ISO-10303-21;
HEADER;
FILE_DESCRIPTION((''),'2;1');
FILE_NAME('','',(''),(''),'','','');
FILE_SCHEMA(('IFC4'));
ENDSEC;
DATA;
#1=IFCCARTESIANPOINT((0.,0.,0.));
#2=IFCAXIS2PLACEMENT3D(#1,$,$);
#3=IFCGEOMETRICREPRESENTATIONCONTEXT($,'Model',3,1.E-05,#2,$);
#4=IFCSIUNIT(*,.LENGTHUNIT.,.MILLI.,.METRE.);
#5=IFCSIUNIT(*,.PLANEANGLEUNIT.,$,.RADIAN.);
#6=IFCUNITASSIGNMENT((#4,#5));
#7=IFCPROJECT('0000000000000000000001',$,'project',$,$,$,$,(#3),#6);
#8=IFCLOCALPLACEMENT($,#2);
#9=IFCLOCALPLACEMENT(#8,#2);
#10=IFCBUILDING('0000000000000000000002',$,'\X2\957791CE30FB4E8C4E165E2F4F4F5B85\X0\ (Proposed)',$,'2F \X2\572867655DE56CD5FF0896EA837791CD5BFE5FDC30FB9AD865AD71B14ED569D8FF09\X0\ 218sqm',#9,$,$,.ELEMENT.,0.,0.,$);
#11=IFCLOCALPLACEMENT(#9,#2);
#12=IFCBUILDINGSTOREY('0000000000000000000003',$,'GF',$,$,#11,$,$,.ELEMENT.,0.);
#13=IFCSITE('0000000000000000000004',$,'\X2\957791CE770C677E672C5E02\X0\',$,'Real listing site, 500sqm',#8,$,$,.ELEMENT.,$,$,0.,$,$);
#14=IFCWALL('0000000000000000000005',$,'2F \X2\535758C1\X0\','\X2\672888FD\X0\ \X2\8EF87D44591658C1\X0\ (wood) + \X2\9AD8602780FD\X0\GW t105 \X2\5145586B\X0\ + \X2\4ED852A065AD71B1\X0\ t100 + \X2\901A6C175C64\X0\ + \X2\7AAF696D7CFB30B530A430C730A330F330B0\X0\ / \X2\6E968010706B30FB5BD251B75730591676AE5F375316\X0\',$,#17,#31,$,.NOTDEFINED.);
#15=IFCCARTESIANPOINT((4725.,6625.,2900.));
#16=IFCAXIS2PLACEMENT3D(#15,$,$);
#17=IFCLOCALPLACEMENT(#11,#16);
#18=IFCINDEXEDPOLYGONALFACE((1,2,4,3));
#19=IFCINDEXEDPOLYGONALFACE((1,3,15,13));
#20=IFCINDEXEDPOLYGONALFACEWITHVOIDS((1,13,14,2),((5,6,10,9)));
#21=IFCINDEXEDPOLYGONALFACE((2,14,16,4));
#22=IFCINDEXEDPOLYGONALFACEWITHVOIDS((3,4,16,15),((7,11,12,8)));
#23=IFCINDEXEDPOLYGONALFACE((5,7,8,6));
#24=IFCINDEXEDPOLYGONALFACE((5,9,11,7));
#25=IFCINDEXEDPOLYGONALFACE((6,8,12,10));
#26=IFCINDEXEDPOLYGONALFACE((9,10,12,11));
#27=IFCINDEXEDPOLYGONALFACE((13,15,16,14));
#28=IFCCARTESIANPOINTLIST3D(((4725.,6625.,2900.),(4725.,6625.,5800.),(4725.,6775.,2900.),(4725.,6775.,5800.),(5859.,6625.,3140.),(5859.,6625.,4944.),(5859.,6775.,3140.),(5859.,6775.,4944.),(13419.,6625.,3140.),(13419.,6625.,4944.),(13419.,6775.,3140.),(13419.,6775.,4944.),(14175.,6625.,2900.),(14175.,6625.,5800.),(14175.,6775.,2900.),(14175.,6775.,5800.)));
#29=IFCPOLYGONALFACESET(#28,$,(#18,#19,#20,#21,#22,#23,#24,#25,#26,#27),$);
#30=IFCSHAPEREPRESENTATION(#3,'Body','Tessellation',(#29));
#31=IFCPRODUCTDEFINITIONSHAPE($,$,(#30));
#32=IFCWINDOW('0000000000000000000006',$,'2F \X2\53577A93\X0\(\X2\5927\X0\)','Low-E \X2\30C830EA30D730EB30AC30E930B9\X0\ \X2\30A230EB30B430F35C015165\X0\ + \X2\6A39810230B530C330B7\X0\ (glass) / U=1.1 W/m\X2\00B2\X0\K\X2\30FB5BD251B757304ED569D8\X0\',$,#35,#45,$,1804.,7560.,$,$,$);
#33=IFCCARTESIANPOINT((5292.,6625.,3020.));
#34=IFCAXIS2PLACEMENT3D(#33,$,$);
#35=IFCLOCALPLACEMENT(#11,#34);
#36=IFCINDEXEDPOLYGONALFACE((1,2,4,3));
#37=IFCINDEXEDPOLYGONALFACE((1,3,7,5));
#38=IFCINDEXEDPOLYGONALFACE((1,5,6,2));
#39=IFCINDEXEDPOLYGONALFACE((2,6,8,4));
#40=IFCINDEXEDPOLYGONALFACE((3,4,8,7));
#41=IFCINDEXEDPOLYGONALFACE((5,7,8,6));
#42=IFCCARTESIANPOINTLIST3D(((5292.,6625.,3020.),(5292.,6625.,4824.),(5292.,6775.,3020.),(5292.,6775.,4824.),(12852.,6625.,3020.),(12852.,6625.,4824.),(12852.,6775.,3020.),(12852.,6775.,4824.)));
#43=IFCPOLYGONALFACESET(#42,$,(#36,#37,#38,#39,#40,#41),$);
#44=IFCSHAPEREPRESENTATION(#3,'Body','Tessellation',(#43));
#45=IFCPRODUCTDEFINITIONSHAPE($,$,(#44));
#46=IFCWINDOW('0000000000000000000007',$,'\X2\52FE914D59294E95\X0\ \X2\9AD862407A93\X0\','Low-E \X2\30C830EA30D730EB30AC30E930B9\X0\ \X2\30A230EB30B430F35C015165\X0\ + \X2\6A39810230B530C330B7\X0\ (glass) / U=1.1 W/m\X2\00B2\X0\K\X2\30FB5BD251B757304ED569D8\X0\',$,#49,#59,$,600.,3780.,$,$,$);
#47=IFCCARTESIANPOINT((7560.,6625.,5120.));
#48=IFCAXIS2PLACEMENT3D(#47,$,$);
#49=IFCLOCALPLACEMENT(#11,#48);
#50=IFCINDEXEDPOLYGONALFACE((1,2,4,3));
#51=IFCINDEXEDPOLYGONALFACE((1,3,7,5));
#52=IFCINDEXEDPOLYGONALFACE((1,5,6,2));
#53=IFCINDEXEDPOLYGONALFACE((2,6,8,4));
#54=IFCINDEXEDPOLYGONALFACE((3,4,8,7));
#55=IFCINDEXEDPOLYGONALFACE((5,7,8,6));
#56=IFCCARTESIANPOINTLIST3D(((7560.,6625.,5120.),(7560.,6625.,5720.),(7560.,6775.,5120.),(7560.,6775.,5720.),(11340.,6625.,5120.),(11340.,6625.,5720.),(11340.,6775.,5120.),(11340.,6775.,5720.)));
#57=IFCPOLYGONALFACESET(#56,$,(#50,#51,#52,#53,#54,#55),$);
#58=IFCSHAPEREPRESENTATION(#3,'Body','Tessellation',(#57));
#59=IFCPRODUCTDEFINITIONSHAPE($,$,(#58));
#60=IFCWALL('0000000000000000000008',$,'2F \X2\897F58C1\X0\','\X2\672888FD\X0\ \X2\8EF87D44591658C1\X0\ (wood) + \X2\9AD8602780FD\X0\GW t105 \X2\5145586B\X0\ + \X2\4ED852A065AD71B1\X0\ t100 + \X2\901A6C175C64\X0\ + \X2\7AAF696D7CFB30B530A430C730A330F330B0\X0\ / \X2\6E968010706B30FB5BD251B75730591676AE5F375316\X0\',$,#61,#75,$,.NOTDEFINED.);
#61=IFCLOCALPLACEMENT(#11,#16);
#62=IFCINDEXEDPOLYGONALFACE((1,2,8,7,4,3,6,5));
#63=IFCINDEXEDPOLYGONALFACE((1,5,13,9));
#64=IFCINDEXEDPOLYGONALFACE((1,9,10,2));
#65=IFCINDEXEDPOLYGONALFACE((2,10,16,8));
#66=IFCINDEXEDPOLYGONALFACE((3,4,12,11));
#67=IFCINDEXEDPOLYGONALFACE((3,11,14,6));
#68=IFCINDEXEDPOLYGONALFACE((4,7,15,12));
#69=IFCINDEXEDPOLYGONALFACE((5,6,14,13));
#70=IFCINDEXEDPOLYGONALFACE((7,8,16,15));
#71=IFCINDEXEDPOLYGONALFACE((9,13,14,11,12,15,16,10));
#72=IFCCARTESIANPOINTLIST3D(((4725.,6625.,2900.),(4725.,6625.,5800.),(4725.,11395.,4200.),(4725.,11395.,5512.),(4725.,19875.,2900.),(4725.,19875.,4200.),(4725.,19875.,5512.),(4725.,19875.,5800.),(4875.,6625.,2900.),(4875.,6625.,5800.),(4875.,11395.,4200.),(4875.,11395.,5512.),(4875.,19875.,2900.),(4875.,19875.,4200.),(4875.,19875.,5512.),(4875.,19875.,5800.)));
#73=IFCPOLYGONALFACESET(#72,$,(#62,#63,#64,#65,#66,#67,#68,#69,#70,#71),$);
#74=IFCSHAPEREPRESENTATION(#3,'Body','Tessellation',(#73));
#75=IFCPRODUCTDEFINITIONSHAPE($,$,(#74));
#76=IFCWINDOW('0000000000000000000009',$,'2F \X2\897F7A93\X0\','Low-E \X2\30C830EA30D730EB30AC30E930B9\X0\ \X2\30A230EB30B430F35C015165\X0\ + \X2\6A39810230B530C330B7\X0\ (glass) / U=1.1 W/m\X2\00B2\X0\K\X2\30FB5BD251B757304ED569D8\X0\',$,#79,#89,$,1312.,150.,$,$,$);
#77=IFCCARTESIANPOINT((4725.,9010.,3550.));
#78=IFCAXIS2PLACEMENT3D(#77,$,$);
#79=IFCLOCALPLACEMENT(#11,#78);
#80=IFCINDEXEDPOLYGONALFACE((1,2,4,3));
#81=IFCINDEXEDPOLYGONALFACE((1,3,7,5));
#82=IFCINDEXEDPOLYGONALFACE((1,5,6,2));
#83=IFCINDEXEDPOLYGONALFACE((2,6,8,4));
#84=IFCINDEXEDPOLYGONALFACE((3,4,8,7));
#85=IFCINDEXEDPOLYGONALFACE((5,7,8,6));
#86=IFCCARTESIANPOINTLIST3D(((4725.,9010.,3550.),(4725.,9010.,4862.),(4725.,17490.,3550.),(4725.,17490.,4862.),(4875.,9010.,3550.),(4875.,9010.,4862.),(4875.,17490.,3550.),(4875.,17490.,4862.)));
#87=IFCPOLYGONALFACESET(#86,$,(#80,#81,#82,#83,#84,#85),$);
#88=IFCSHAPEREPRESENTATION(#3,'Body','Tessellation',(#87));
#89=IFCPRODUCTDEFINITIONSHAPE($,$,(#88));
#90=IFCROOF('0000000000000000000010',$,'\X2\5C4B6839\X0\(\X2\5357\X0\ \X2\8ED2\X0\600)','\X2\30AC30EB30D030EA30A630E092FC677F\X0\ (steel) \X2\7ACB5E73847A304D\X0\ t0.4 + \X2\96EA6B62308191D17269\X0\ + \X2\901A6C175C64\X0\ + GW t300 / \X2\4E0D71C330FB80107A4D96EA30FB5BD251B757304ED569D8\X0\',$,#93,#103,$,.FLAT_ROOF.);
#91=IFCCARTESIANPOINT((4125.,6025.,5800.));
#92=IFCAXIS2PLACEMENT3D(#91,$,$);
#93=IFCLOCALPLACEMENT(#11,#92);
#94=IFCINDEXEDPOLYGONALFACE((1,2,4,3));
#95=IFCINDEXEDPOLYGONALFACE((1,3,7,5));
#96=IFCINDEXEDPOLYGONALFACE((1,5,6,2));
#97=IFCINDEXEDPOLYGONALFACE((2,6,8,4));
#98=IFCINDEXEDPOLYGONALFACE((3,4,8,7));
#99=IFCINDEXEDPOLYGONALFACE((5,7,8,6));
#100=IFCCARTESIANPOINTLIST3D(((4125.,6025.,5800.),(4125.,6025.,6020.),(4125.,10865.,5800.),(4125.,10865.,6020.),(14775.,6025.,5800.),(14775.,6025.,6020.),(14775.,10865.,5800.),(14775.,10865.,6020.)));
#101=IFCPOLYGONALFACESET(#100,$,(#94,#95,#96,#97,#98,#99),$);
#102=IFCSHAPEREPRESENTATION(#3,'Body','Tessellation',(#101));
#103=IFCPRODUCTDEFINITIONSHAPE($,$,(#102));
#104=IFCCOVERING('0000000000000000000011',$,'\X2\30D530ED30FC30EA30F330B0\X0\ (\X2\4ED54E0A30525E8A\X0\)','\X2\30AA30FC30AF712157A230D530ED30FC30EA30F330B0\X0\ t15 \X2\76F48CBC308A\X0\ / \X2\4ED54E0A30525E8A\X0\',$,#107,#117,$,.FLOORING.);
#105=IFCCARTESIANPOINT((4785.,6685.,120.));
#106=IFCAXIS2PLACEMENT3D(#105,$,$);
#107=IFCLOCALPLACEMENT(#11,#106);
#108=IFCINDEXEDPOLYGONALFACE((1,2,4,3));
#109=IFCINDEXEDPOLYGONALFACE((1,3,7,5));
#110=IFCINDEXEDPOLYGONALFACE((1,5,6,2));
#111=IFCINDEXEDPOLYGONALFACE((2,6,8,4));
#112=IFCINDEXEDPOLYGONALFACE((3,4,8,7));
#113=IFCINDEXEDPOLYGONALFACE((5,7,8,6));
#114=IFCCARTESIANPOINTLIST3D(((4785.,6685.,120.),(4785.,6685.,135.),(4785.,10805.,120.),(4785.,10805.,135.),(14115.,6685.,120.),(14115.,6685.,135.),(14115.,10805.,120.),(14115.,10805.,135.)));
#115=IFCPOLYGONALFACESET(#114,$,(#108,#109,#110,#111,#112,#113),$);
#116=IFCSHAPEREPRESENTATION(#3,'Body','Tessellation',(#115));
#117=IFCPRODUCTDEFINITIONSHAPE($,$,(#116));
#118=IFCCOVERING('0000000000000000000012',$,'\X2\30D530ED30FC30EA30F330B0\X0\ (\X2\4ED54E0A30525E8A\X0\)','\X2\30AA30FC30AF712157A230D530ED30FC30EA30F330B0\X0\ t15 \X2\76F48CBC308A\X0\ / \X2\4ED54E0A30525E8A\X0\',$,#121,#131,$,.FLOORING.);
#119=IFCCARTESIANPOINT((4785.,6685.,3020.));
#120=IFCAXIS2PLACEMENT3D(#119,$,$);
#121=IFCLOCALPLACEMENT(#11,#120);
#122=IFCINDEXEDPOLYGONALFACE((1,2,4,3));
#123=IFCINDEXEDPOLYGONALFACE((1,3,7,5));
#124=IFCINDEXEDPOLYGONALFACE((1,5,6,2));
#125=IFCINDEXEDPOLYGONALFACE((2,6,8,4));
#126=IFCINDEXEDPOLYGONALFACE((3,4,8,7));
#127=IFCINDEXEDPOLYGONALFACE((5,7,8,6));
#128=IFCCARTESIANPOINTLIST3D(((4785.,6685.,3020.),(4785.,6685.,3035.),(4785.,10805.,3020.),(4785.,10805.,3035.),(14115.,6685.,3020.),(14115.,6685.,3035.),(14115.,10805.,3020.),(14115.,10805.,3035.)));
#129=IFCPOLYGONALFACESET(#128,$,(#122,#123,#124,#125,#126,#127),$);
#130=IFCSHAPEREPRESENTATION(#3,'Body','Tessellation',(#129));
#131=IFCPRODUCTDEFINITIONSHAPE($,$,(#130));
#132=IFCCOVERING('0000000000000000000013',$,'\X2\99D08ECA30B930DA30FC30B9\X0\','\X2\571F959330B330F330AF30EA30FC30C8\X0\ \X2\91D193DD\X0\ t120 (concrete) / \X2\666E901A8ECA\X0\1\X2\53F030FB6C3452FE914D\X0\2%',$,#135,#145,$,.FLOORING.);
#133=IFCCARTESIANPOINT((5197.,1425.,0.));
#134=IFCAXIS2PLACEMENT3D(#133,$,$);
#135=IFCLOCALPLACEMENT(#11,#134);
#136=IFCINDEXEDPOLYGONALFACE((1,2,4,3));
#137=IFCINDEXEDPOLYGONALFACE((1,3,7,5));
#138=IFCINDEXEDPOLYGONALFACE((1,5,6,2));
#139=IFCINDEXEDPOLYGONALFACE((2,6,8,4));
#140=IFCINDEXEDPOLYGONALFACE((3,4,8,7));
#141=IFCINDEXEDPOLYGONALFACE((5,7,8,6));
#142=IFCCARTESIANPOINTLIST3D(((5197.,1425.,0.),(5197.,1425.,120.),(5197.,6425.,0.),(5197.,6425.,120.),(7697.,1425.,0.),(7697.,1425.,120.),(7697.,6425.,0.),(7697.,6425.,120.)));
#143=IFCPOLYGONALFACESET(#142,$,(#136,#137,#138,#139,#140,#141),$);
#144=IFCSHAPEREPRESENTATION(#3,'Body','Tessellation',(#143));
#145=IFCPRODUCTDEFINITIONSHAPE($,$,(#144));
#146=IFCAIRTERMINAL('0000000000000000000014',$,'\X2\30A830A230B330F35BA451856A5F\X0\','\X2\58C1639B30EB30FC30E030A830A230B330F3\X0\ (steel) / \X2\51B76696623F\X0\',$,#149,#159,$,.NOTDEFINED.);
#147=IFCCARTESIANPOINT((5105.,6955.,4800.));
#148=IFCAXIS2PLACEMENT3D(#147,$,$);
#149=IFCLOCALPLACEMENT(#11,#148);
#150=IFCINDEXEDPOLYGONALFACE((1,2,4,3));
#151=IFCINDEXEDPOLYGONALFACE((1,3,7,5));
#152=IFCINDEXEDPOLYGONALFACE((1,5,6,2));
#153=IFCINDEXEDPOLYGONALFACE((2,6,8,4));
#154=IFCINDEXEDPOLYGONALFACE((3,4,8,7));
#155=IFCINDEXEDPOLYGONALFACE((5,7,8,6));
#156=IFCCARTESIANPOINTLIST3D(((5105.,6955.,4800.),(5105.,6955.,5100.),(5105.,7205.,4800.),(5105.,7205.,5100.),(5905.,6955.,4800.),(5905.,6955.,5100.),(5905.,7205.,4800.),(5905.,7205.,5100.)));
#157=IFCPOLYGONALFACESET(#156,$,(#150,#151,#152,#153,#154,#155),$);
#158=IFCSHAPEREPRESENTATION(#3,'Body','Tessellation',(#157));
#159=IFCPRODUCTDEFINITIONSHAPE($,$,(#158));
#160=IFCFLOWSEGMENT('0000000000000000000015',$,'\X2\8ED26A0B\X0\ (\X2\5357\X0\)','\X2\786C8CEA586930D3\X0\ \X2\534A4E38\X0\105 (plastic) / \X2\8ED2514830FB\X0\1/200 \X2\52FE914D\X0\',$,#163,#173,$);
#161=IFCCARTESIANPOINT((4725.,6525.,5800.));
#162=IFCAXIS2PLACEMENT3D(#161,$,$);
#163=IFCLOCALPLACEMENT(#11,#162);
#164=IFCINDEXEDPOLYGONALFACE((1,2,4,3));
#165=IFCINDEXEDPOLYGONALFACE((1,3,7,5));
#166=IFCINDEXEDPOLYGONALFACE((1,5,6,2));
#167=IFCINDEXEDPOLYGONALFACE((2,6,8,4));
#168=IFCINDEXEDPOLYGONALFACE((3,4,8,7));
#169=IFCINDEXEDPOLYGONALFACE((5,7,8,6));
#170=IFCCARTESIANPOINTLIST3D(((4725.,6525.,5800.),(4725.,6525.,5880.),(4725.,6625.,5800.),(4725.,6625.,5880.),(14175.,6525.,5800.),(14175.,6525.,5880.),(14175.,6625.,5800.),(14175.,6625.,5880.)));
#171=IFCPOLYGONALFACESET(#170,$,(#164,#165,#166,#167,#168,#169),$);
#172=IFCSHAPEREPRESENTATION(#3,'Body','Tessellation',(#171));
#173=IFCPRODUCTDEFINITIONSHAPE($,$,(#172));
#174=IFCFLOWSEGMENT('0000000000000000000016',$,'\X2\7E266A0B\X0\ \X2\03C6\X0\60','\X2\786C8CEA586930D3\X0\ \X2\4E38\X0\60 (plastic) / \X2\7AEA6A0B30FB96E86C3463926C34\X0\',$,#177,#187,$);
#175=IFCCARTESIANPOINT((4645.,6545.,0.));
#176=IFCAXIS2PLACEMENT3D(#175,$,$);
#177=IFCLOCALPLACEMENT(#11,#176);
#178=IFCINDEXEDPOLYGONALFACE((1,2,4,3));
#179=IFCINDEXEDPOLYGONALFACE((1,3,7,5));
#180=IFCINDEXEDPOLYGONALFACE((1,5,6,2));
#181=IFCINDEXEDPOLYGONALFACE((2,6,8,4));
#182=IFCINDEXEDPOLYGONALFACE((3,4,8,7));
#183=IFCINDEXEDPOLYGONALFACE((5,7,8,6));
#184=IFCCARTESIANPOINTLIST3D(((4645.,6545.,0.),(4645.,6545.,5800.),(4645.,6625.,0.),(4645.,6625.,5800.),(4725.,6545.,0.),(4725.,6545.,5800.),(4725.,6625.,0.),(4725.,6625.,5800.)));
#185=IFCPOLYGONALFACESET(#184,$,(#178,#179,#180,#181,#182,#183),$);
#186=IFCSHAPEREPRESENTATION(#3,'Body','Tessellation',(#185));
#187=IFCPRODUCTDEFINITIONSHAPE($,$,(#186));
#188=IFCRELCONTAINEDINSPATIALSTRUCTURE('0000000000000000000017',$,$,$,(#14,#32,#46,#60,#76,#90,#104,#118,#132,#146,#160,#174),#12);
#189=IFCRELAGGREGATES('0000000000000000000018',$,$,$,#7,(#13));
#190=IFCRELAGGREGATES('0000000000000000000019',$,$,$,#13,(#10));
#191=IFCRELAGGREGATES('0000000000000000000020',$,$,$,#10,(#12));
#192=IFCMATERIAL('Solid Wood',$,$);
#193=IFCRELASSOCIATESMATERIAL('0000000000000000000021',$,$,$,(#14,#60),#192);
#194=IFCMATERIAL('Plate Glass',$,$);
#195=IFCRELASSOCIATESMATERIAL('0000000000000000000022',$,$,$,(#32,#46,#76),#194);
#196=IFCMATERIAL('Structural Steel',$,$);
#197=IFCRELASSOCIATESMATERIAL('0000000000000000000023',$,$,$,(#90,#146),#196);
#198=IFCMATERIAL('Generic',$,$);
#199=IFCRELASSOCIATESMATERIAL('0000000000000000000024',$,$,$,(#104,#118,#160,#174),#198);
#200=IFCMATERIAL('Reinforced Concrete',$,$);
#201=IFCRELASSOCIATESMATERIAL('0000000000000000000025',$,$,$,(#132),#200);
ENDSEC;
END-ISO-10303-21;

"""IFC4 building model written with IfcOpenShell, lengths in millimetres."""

from ifc_helpers import new_model, si_unit, frame, frame_2d, origin, place, context, project, spatial, rectangle, extrude, material, element, fill, save


model = new_model("IFC4")

# Units and contexts
model_context = context("Model", 3, precision=1e-05, world=origin())
ifc_project = project(units=[si_unit("LENGTHUNIT", "METRE", prefix="MILLI"), si_unit("PLANEANGLEUNIT", "RADIAN")], contexts=[model_context])

# Site, building, storey
site_placement = place(None, origin())
site = spatial("IfcSite", under=ifc_project, at=site_placement, Name="長野県松本市", ObjectType="Real listing site, 500sqm", CompositionType="ELEMENT", RefElevation=0.0)
building_placement = place(site_placement, origin())
building = spatial("IfcBuilding", under=site, at=building_placement, Name="長野・二世帯住宅 (Proposed)", ObjectType="2F 在来工法（雪荷重対応・高断熱仕様） 218sqm", CompositionType="ELEMENT", ElevationOfRefHeight=0.0, ElevationOfTerrain=0.0)
storey_placement = place(building_placement, origin())
storey = spatial("IfcBuildingStorey", under=building, at=storey_placement, Name="GF", CompositionType="ELEMENT", Elevation=0.0)

# Shared definitions
ifc_material_1 = material(Name="Solid Wood")

# Shared definitions
ifc_material_2 = material(Name="Reinforced Concrete")

# Shared definitions
ifc_material_3 = material(Name="Plate Glass")

# Wall, openings, windows
wall_1_placement = place(storey_placement, frame((4725.0, 6625.0, 2900.0)))
wall_1 = element("IfcWall", 1, at=wall_1_placement, inside=storey, material=ifc_material_1, Name="2F 南壁", Description="木製 軸組外壁 (wood) + 高性能GW t105 充填 + 付加断熱 t100 + 通気層 + 窯業系サイディング / 準耐火・寒冷地外皮強化", PredefinedType="NOTDEFINED", context=model_context, shape_type="SweptSolid", body=[
    extrude(rectangle(XDim=9450.0, YDim=150.0, at=frame_2d((4725.0, 75.0))), frame((4725.0, 6625.0, 2900.0)), (0.0, 0.0, 1.0), 2900.0),
])
opening_1_placement = place(storey_placement, frame((5292.0, 6625.0, 3020.0)))
opening_1 = element("IfcOpeningElement", 2, at=opening_1_placement, cuts=wall_1, PredefinedType="NOTDEFINED", context=model_context, shape_type="SweptSolid", body=[
    extrude(rectangle(XDim=7560.0, YDim=150.0, at=frame_2d((3780.0, 75.0))), frame((5292.0, 6625.0, 3020.0)), (0.0, 0.0, 1.0), 1804.0),
])
opening_2_placement = place(storey_placement, frame((7560.0, 6625.0, 5120.0)))
opening_2 = element("IfcOpeningElement", 3, at=opening_2_placement, cuts=wall_1, PredefinedType="NOTDEFINED", context=model_context, shape_type="SweptSolid", body=[
    extrude(rectangle(XDim=3780.0, YDim=150.0, at=frame_2d((1890.0, 75.0))), frame((7560.0, 6625.0, 5120.0)), (0.0, 0.0, 1.0), 600.0),
])
window_1_placement = place(storey_placement, frame((5292.0, 6625.0, 3020.0)))
window_1 = element("IfcWindow", 4, at=window_1_placement, inside=storey, material=ifc_material_3, Name="2F 南窓(大)", Description="Low-E トリプルガラス アルゴン封入 + 樹脂サッシ (glass) / U=1.1 W/m²K・寒冷地仕様", OverallHeight=1804.0, OverallWidth=7560.0, context=model_context, shape_type="SweptSolid", body=[
    extrude(rectangle(XDim=7560.0, YDim=150.0, at=frame_2d((3780.0, 75.0))), frame((5292.0, 6625.0, 3020.0)), (0.0, 0.0, 1.0), 1804.0),
])
fill(opening_1, window_1)
window_2_placement = place(storey_placement, frame((7560.0, 6625.0, 5120.0)))
window_2 = element("IfcWindow", 5, at=window_2_placement, inside=storey, material=ifc_material_3, Name="勾配天井 高所窓", Description="Low-E トリプルガラス アルゴン封入 + 樹脂サッシ (glass) / U=1.1 W/m²K・寒冷地仕様", OverallHeight=600.0, OverallWidth=3780.0, context=model_context, shape_type="SweptSolid", body=[
    extrude(rectangle(XDim=3780.0, YDim=150.0, at=frame_2d((1890.0, 75.0))), frame((7560.0, 6625.0, 5120.0)), (0.0, 0.0, 1.0), 600.0),
])
fill(opening_2, window_2)

# Wall, opening, window
wall_2_placement = place(storey_placement, frame((4725.0, 6625.0, 2900.0)))
wall_2 = element("IfcWall", 6, at=wall_2_placement, inside=storey, material=ifc_material_1, Name="2F 西壁", Description="木製 軸組外壁 (wood) + 高性能GW t105 充填 + 付加断熱 t100 + 通気層 + 窯業系サイディング / 準耐火・寒冷地外皮強化", PredefinedType="NOTDEFINED", context=model_context, shape_type="SweptSolid", body=[
    extrude(rectangle(XDim=150.0, YDim=13250.0, at=frame_2d((75.0, 6625.0))), frame((4725.0, 6625.0, 2900.0)), (0.0, 0.0, 1.0), 2900.0),
])
opening_3_placement = place(storey_placement, frame((4725.0, 9010.0, 3550.0)))
opening_3 = element("IfcOpeningElement", 7, at=opening_3_placement, cuts=wall_2, PredefinedType="NOTDEFINED", context=model_context, shape_type="SweptSolid", body=[
    extrude(rectangle(XDim=150.0, YDim=8480.0, at=frame_2d((75.0, 4240.0))), frame((4725.0, 9010.0, 3550.0)), (0.0, 0.0, 1.0), 1312.0),
])
window_3_placement = place(storey_placement, frame((4725.0, 9010.0, 3550.0)))
window_3 = element("IfcWindow", 8, at=window_3_placement, inside=storey, material=ifc_material_3, Name="2F 西窓", Description="Low-E トリプルガラス アルゴン封入 + 樹脂サッシ (glass) / U=1.1 W/m²K・寒冷地仕様", OverallHeight=1312.0, OverallWidth=150.0, context=model_context, shape_type="SweptSolid", body=[
    extrude(rectangle(XDim=150.0, YDim=8480.0, at=frame_2d((75.0, 4240.0))), frame((4725.0, 9010.0, 3550.0)), (0.0, 0.0, 1.0), 1312.0),
])
fill(opening_3, window_3)

# Roof
ifc_material_4 = material(Name="Structural Steel")
for number, where, name in (
    (9, (4125.0, 6025.0, 5800.0), "屋根(南 軒600)"),
):
    element("IfcRoof", number, at=place(storey_placement, frame(where)), inside=storey, material=ifc_material_4, Name=name, Description="ガルバリウム鋼板 (steel) 立平葺き t0.4 + 雪止め金物 + 通気層 + GW t300 / 不燃・耐積雪・寒冷地仕様", PredefinedType="FLAT_ROOF", context=model_context, shape_type="SweptSolid", body=[
        extrude(rectangle(XDim=10650.0, YDim=4840.0, at=frame_2d((5325.0, 2420.0))), frame((4125.0, 6025.0, 5800.0)), (0.0, 0.0, 1.0), 220.0),
    ])

# Coverings
ifc_material_5 = material(Name="Generic")
covering_1_placement = place(storey_placement, frame((4785.0, 6685.0, 120.0)))
element("IfcCovering", 10, at=covering_1_placement, inside=storey, material=ifc_material_5, Name="フローリング (仕上げ床)", Description="オーク無垢フローリング t15 直貼り / 仕上げ床", PredefinedType="FLOORING", context=model_context, shape_type="SweptSolid", body=[
    extrude(rectangle(XDim=9330.0, YDim=4120.0, at=frame_2d((4665.0, 2060.0))), frame((4785.0, 6685.0, 120.0)), (0.0, 0.0, 1.0), 15.0),
])
covering_2_placement = place(storey_placement, frame((4785.0, 6685.0, 3020.0)))
element("IfcCovering", 11, at=covering_2_placement, inside=storey, material=ifc_material_5, Name="フローリング (仕上げ床)", Description="オーク無垢フローリング t15 直貼り / 仕上げ床", PredefinedType="FLOORING", context=model_context, shape_type="SweptSolid", body=[
    extrude(rectangle(XDim=9330.0, YDim=4120.0, at=frame_2d((4665.0, 2060.0))), frame((4785.0, 6685.0, 3020.0)), (0.0, 0.0, 1.0), 15.0),
])
covering_3_placement = place(storey_placement, frame((5197.0, 1425.0, 0.0)))
element("IfcCovering", 12, at=covering_3_placement, inside=storey, material=ifc_material_2, Name="駐車スペース", Description="土間コンクリート 金鏝 t120 (concrete) / 普通車1台・水勾配2%", PredefinedType="FLOORING", context=model_context, shape_type="SweptSolid", body=[
    extrude(rectangle(XDim=2500.0, YDim=5000.0, at=frame_2d((1250.0, 2500.0))), frame((5197.0, 1425.0, 0.0)), (0.0, 0.0, 1.0), 120.0),
])

# Air terminal
air_terminal_placement = place(storey_placement, frame((5105.0, 6955.0, 4800.0)))
element("IfcAirTerminal", 13, at=air_terminal_placement, inside=storey, material=ifc_material_4, Name="エアコン室内機", Description="壁掛ルームエアコン (steel) / 冷暖房", PredefinedType="NOTDEFINED", context=model_context, shape_type="SweptSolid", body=[
    extrude(rectangle(XDim=800.0, YDim=250.0, at=frame_2d((400.0, 125.0))), frame((5105.0, 6955.0, 4800.0)), (0.0, 0.0, 1.0), 300.0),
])

# Flow segments
flow_segment_1_placement = place(storey_placement, frame((4725.0, 6525.0, 5800.0)))
element("IfcFlowSegment", 14, at=flow_segment_1_placement, inside=storey, material=ifc_material_5, Name="軒樋 (南)", Description="硬質塩ビ 半丸105 (plastic) / 軒先・1/200 勾配", context=model_context, shape_type="SweptSolid", body=[
    extrude(rectangle(XDim=9450.0, YDim=100.0, at=frame_2d((4725.0, 50.0))), frame((4725.0, 6525.0, 5800.0)), (0.0, 0.0, 1.0), 80.0),
])
flow_segment_2_placement = place(storey_placement, frame((4645.0, 6545.0, 0.0)))
element("IfcFlowSegment", 15, at=flow_segment_2_placement, inside=storey, material=ifc_material_5, Name="縦樋 φ60", Description="硬質塩ビ 丸60 (plastic) / 竪樋・雨水排水", context=model_context, shape_type="SweptSolid", body=[
    extrude(rectangle(XDim=80.0, YDim=80.0, at=frame_2d((40.0, 40.0))), frame((4645.0, 6545.0, 0.0)), (0.0, 0.0, 1.0), 5800.0),
])

save(model, "model.ifc")
